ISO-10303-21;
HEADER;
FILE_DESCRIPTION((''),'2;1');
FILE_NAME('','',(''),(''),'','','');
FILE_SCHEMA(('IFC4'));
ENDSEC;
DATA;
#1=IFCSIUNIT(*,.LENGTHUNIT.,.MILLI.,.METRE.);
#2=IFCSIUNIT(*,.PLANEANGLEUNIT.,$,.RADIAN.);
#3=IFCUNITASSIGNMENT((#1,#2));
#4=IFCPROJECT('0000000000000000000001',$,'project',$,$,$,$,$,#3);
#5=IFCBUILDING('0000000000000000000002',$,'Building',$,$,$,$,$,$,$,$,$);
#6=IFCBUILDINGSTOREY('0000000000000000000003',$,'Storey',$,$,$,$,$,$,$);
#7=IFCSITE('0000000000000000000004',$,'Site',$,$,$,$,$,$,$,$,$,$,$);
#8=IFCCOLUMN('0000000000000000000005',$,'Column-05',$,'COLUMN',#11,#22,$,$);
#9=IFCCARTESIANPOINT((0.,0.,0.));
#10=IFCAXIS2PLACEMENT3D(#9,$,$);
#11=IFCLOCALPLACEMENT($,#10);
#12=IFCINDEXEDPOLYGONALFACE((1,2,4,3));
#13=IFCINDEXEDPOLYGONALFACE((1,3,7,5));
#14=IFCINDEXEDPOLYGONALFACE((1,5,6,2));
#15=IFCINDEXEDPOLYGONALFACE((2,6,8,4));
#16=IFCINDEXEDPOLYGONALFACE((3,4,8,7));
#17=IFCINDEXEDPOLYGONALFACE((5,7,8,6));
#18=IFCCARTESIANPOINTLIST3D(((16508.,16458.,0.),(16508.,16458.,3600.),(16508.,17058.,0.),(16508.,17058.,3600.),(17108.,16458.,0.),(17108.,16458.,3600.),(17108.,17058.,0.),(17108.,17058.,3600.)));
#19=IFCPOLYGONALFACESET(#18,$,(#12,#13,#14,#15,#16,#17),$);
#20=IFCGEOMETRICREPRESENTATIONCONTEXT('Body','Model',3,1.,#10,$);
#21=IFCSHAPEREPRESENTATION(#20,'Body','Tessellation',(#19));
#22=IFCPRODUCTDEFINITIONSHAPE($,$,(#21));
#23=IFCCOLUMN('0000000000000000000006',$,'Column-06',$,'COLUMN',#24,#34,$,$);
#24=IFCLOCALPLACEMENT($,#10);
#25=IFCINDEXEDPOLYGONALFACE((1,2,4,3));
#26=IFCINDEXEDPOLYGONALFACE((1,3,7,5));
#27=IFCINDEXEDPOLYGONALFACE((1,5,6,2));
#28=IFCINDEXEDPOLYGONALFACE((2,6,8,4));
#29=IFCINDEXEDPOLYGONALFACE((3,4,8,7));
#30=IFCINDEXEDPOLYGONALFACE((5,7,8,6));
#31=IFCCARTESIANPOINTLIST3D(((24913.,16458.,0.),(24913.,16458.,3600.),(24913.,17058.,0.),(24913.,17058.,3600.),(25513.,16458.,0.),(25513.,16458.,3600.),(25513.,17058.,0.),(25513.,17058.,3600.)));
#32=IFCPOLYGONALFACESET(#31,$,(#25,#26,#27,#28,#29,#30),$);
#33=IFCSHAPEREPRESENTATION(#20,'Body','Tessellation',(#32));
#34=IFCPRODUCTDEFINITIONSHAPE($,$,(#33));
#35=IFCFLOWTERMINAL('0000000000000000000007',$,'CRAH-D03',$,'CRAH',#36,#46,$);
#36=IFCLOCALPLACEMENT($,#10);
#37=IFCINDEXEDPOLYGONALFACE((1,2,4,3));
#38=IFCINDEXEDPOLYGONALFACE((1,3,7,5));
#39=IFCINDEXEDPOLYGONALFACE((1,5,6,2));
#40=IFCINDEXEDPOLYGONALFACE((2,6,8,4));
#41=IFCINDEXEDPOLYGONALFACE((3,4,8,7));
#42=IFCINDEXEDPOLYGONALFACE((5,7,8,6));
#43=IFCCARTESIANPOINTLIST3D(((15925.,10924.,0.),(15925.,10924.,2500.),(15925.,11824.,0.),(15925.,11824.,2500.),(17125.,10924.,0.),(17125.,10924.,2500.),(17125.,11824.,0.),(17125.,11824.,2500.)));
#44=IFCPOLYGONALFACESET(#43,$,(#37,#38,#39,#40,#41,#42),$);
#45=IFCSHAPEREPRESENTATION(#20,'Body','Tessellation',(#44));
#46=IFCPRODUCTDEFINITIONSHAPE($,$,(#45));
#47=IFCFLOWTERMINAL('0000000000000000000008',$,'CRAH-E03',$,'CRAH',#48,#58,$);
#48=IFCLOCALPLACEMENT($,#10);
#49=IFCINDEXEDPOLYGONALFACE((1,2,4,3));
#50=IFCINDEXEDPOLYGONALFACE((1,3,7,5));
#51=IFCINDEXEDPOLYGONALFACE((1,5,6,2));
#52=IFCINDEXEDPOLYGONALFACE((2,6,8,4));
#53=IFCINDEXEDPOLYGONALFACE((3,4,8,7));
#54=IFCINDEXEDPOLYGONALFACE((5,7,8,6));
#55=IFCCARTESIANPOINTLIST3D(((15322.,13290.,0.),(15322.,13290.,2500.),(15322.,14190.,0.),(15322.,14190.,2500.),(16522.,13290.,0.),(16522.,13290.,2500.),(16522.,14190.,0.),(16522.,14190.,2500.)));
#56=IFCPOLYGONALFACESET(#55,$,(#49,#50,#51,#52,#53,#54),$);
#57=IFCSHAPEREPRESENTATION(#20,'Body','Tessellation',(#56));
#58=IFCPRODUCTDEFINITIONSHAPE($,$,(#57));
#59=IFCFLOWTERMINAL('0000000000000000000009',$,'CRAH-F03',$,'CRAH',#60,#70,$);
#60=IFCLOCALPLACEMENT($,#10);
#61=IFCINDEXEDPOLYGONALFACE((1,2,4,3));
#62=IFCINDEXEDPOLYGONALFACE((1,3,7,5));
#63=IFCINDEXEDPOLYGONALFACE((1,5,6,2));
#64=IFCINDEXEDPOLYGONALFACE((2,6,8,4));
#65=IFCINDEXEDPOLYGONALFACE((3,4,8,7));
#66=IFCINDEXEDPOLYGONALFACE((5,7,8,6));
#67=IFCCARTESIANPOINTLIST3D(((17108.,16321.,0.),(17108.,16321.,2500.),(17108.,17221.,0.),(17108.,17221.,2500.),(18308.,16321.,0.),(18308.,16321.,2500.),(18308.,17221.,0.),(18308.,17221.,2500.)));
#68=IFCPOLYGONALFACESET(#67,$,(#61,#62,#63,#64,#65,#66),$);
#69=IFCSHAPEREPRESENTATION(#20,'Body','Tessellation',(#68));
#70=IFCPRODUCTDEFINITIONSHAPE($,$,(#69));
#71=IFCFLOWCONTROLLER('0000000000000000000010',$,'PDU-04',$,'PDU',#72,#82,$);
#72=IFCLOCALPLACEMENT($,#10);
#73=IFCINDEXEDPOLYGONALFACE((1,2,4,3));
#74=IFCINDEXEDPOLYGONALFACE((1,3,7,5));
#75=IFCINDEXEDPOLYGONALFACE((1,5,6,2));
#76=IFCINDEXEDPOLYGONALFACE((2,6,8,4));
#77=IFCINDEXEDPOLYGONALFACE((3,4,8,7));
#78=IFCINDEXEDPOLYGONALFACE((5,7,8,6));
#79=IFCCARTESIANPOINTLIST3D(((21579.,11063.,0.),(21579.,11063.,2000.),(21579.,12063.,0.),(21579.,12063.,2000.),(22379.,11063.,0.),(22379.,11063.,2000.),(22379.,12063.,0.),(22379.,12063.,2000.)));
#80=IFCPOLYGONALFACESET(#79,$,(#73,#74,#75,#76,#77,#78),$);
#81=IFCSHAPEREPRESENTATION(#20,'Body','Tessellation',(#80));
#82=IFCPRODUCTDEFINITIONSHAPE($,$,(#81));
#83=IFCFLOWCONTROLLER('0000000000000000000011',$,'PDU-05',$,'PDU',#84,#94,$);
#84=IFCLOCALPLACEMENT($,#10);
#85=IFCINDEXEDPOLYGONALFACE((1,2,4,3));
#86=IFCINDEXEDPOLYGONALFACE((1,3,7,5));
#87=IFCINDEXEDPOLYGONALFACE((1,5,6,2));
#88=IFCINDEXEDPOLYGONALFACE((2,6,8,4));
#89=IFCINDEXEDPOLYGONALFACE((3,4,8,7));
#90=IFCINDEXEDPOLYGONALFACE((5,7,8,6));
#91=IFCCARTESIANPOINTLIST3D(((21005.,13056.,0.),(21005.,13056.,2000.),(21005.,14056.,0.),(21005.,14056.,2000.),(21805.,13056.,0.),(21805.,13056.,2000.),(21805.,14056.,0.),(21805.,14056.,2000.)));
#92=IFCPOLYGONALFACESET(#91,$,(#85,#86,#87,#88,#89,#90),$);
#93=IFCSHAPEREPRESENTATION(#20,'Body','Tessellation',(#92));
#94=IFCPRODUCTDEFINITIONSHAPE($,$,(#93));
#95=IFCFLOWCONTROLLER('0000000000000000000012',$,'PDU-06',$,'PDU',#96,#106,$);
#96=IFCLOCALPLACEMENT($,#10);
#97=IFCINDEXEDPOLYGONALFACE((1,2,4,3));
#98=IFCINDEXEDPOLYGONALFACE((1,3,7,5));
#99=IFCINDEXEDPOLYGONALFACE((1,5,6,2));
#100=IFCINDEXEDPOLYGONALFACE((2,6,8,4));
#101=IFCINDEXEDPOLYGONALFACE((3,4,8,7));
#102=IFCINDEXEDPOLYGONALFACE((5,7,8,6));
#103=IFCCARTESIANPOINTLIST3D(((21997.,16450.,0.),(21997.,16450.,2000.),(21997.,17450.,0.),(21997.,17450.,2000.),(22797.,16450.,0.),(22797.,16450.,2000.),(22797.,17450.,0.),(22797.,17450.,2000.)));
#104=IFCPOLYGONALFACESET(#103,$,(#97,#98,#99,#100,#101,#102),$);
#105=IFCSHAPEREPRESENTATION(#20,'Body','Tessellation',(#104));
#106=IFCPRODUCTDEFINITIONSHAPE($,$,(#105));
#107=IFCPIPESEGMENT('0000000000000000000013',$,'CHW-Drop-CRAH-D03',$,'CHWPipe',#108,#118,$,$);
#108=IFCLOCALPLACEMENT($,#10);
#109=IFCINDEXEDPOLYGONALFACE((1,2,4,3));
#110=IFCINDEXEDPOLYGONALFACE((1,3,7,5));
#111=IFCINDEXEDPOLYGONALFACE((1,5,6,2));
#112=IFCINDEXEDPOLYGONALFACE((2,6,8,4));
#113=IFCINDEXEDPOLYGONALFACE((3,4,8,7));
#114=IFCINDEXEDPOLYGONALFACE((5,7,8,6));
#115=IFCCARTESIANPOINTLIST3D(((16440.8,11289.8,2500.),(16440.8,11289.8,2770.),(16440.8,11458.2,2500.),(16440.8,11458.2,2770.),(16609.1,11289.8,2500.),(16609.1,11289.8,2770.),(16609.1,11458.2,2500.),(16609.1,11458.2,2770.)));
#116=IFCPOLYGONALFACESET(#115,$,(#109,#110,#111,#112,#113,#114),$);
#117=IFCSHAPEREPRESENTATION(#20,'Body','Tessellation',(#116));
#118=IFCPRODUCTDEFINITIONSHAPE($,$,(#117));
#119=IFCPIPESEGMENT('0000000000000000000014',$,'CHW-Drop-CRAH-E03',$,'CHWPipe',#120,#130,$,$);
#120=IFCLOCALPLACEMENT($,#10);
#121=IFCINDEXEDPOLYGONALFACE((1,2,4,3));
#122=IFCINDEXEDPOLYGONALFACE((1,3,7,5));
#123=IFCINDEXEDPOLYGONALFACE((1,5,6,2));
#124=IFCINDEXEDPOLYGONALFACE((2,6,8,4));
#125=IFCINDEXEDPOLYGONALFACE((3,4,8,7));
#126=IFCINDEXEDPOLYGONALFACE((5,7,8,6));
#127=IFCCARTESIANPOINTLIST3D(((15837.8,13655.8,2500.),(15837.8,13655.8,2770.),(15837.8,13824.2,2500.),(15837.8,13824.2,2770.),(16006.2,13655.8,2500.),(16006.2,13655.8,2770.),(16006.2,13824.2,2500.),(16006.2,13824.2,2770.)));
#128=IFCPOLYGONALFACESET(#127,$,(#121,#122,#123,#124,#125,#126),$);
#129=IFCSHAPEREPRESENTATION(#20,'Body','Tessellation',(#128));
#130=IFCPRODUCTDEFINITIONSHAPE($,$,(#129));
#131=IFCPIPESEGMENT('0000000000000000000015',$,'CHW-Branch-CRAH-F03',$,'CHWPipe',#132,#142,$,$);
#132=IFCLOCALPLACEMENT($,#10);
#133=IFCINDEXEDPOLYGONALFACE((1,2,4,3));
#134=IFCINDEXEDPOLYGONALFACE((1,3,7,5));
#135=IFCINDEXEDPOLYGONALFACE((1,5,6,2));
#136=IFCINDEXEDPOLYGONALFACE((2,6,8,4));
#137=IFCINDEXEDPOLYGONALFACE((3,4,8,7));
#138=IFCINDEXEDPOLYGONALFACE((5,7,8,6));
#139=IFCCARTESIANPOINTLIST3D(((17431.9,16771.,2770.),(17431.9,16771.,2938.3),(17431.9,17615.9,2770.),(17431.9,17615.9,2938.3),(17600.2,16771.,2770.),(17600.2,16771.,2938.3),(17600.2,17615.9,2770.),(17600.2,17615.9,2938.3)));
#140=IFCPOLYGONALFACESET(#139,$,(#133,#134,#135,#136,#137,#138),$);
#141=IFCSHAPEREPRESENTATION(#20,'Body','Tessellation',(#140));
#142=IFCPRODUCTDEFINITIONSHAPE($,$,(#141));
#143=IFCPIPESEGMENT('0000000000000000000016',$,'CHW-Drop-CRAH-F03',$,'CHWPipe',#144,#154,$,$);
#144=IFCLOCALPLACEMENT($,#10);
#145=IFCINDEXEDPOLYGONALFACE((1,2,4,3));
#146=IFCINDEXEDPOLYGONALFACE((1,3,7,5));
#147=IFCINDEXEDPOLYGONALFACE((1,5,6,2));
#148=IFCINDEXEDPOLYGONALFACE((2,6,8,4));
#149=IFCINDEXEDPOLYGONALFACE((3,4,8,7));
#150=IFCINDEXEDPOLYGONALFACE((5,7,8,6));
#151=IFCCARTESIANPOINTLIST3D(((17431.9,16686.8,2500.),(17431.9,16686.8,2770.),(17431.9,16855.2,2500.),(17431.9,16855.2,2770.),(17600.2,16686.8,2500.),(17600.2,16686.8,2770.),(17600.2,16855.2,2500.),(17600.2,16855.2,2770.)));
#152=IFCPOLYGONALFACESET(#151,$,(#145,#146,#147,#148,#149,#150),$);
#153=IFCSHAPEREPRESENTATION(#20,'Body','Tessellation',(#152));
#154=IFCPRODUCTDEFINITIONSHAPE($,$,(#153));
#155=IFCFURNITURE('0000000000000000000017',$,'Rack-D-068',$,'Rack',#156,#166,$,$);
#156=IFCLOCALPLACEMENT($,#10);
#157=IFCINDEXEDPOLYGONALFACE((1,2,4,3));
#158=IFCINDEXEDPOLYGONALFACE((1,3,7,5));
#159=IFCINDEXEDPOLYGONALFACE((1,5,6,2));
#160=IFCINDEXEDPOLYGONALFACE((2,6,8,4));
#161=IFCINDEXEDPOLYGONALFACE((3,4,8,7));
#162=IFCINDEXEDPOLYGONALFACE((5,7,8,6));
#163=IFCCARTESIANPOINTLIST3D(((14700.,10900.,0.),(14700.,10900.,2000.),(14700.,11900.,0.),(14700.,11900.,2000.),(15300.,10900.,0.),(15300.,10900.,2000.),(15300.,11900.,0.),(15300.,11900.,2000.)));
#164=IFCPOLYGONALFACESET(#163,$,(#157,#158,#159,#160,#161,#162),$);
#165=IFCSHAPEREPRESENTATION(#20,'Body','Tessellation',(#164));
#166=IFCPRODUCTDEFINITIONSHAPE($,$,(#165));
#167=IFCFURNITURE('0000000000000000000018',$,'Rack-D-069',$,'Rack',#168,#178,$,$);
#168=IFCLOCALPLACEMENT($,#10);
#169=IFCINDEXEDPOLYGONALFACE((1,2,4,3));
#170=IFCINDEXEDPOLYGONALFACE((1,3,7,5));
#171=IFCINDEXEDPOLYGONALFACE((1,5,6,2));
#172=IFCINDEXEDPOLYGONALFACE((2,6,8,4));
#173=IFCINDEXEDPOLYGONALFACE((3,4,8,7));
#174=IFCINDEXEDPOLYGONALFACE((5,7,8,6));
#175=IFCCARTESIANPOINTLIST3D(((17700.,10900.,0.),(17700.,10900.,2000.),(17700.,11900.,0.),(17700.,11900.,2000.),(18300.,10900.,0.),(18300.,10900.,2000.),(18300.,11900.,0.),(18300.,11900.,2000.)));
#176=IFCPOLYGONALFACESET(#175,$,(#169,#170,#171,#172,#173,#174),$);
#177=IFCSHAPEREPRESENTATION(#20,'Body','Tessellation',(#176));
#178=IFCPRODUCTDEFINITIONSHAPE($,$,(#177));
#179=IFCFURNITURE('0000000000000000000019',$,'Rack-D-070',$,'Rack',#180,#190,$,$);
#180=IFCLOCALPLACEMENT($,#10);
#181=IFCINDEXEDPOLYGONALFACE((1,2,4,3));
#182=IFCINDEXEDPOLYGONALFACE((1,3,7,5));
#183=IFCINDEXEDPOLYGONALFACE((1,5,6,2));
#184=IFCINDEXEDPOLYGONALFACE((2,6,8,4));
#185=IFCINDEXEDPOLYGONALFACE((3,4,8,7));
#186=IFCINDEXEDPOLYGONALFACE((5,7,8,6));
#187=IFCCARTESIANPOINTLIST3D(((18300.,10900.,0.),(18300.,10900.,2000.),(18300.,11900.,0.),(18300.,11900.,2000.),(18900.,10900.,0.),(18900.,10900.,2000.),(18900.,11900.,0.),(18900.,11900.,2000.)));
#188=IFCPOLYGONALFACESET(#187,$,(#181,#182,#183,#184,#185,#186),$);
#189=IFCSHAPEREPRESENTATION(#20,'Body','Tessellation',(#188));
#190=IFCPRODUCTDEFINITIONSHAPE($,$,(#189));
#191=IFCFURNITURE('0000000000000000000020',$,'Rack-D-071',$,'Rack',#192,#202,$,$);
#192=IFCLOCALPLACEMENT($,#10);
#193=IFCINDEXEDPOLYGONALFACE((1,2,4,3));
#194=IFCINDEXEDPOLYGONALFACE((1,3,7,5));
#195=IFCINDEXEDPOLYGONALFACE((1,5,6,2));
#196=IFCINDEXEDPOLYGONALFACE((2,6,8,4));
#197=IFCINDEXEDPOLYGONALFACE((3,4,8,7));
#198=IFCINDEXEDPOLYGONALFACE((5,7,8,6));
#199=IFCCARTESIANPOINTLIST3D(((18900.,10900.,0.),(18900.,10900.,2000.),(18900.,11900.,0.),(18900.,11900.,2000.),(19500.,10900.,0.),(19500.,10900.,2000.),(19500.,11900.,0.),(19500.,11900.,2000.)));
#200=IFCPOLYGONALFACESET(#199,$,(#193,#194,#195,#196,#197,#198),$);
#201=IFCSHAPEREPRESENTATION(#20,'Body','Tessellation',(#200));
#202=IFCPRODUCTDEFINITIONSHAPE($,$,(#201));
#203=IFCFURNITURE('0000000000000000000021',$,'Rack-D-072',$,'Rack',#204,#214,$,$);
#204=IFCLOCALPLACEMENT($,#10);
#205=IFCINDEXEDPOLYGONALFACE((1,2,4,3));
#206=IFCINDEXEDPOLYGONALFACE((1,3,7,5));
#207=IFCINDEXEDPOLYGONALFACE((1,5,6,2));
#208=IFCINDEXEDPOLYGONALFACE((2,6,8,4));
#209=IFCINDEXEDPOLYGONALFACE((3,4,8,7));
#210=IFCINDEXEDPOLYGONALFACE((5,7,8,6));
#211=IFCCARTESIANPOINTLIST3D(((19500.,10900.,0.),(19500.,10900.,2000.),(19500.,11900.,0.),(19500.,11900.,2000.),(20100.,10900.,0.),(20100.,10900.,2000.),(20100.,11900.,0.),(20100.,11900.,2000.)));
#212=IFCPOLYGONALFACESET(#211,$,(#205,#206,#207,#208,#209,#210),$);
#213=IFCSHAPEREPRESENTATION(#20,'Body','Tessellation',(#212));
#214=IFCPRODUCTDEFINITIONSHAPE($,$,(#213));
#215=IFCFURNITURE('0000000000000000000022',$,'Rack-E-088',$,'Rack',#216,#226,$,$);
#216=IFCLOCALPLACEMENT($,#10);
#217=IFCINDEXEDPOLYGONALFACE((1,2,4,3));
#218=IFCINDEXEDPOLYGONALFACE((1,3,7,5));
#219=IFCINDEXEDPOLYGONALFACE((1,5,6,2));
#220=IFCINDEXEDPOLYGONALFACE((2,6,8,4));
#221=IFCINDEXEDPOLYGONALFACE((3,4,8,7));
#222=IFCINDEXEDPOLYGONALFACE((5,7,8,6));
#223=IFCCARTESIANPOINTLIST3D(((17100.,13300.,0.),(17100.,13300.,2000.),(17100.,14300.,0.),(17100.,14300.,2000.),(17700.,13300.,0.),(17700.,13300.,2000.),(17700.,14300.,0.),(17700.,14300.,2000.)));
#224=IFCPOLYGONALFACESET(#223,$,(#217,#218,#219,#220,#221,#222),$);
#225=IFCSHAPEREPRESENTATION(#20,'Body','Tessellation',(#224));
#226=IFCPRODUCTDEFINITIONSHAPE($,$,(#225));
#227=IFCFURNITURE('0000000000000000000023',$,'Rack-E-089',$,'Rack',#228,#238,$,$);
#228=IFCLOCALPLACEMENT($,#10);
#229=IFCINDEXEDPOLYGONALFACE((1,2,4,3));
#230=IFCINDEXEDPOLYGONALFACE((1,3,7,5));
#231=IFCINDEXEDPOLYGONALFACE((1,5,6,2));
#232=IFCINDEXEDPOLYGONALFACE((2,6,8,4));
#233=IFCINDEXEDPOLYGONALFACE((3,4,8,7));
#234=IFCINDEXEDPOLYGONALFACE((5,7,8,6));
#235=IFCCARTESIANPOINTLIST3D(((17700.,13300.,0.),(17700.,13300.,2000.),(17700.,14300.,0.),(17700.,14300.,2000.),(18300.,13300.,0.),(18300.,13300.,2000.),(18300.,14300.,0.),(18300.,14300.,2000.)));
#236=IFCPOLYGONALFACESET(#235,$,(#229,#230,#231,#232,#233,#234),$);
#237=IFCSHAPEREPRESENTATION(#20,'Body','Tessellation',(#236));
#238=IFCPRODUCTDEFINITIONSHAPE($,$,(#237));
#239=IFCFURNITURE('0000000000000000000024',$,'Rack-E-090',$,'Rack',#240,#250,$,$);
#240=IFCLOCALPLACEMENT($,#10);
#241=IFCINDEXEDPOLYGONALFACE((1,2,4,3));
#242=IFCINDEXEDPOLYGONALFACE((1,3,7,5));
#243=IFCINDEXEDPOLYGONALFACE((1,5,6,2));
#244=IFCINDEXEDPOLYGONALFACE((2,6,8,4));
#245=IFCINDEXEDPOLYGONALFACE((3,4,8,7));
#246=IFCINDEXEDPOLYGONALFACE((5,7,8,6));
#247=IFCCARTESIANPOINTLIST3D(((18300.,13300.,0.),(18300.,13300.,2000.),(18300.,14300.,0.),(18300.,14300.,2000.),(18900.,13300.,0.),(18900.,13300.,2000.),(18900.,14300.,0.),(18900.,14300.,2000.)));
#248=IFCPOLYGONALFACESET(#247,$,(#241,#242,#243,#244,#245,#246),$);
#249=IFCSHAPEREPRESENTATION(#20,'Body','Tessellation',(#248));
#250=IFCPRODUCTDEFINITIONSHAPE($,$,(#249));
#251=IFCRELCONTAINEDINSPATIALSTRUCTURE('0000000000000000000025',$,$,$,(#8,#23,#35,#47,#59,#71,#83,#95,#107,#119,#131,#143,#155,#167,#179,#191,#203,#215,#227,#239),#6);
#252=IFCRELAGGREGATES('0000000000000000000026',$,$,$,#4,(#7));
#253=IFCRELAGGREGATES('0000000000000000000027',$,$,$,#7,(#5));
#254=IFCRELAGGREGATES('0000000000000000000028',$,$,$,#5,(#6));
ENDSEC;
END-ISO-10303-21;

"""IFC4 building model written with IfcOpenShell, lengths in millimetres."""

from ifc_helpers import new_model, si_unit, frame, origin, place, context, project, spatial, rectangle, extrude, element, save


model = new_model("IFC4")

# Units and contexts
model_context = context("Model", 3, precision=1.0, world=origin(), identifier="Body")
ifc_project = project(units=[si_unit("LENGTHUNIT", "METRE", prefix="MILLI"), si_unit("PLANEANGLEUNIT", "RADIAN")])

# Site, building, storey
site = spatial("IfcSite", under=ifc_project, Name="Site")
building = spatial("IfcBuilding", under=site, Name="Building")
storey = spatial("IfcBuildingStorey", under=building, Name="Storey")

# Columns
for number, where, z_axis, x_axis, name in (
    (1, (16808.0, 16758.0, 0.0), (0.0, 0.0, 1.0), (1.0, 0.0, 0.0), "Column-05"),
    (2, (25213.0, 16758.0, 0.0), (0.0, 0.0, 1.0), (1.0, 0.0, 0.0), "Column-06"),
):
    element("IfcColumn", number, at=place(None, frame(where, z_axis=z_axis, x_axis=x_axis)), inside=storey, Name=name, ObjectType="COLUMN", context=model_context, shape_type="SweptSolid", body=[
        extrude(rectangle(XDim=600.0, YDim=600.0), origin(), (0.0, 0.0, 1.0), 3600.0),
    ])

# Flow terminals
for number, where, z_axis, x_axis, name in (
    (3, (16525.0, 11374.0, 0.0), (0.0, 0.0, 1.0), (1.0, 0.0, 0.0), "CRAH-D03"),
    (4, (15922.0, 13740.0, 0.0), (0.0, 0.0, 1.0), (1.0, 0.0, 0.0), "CRAH-E03"),
    (5, (17708.0, 16771.0, 0.0), (0.0, 0.0, 1.0), (1.0, 0.0, 0.0), "CRAH-F03"),
):
    element("IfcFlowTerminal", number, at=place(None, frame(where, z_axis=z_axis, x_axis=x_axis)), inside=storey, Name=name, ObjectType="CRAH", context=model_context, shape_type="SweptSolid", body=[
        extrude(rectangle(XDim=1200.0, YDim=900.0), origin(), (0.0, 0.0, 1.0), 2500.0),
    ])

# Flow controllers
for number, where, z_axis, x_axis, name in (
    (6, (21979.0, 11563.0, 0.0), (0.0, 0.0, 1.0), (1.0, 0.0, 0.0), "PDU-04"),
    (7, (21405.0, 13556.0, 0.0), (0.0, 0.0, 1.0), (1.0, 0.0, 0.0), "PDU-05"),
    (8, (22397.0, 16950.0, 0.0), (0.0, 0.0, 1.0), (1.0, 0.0, 0.0), "PDU-06"),
):
    element("IfcFlowController", number, at=place(None, frame(where, z_axis=z_axis, x_axis=x_axis)), inside=storey, Name=name, ObjectType="PDU", context=model_context, shape_type="SweptSolid", body=[
        extrude(rectangle(XDim=800.0, YDim=1000.0), origin(), (0.0, 0.0, 1.0), 2000.0),
    ])

# Pipe segments
for number, where, z_axis, x_axis, name in (
    (9, (16525.0, 11374.0, 2500.0), (0.0, 0.0, 1.0), (1.0, 0.0, 0.0), "CHW-Drop-CRAH-D03"),
    (10, (15922.0, 13740.0, 2500.0), (0.0, 0.0, 1.0), (1.0, 0.0, 0.0), "CHW-Drop-CRAH-E03"),
):
    element("IfcPipeSegment", number, at=place(None, frame(where, z_axis=z_axis, x_axis=x_axis)), inside=storey, Name=name, ObjectType="CHWPipe", context=model_context, shape_type="SweptSolid", body=[
        extrude(rectangle(XDim=168.3, YDim=168.3), origin(), (0.0, 0.0, 1.0), 270.0),
    ])
pipe_segment_1_placement = place(None, frame((17516.0, 17193.4, 2770.0), z_axis=(0.0, 0.0, 1.0), x_axis=(1.0, 0.0, 0.0)))
element("IfcPipeSegment", 11, at=pipe_segment_1_placement, inside=storey, Name="CHW-Branch-CRAH-F03", ObjectType="CHWPipe", context=model_context, shape_type="SweptSolid", body=[
    extrude(rectangle(XDim=168.3, YDim=844.8), origin(), (0.0, 0.0, 1.0), 168.3),
])
pipe_segment_2_placement = place(None, frame((17516.0, 16771.0, 2500.0), z_axis=(0.0, 0.0, 1.0), x_axis=(1.0, 0.0, 0.0)))
element("IfcPipeSegment", 12, at=pipe_segment_2_placement, inside=storey, Name="CHW-Drop-CRAH-F03", ObjectType="CHWPipe", context=model_context, shape_type="SweptSolid", body=[
    extrude(rectangle(XDim=168.3, YDim=168.3), origin(), (0.0, 0.0, 1.0), 270.0),
])

# Furniture
for number, where, z_axis, x_axis, name in (
    (13, (15000.0, 11400.0, 0.0), (0.0, 0.0, 1.0), (1.0, 0.0, 0.0), "Rack-D-068"),
    (14, (18000.0, 11400.0, 0.0), (0.0, 0.0, 1.0), (1.0, 0.0, 0.0), "Rack-D-069"),
    (15, (18600.0, 11400.0, 0.0), (0.0, 0.0, 1.0), (1.0, 0.0, 0.0), "Rack-D-070"),
    (16, (19200.0, 11400.0, 0.0), (0.0, 0.0, 1.0), (1.0, 0.0, 0.0), "Rack-D-071"),
    (17, (19800.0, 11400.0, 0.0), (0.0, 0.0, 1.0), (1.0, 0.0, 0.0), "Rack-D-072"),
    (18, (17400.0, 13800.0, 0.0), (0.0, 0.0, 1.0), (1.0, 0.0, 0.0), "Rack-E-088"),
    (19, (18000.0, 13800.0, 0.0), (0.0, 0.0, 1.0), (1.0, 0.0, 0.0), "Rack-E-089"),
    (20, (18600.0, 13800.0, 0.0), (0.0, 0.0, 1.0), (1.0, 0.0, 0.0), "Rack-E-090"),
):
    element("IfcFurniture", number, at=place(None, frame(where, z_axis=z_axis, x_axis=x_axis)), inside=storey, Name=name, ObjectType="Rack", context=model_context, shape_type="SweptSolid", body=[
        extrude(rectangle(XDim=600.0, YDim=1000.0), origin(), (0.0, 0.0, 1.0), 2000.0),
    ])

save(model, "model.ifc")
